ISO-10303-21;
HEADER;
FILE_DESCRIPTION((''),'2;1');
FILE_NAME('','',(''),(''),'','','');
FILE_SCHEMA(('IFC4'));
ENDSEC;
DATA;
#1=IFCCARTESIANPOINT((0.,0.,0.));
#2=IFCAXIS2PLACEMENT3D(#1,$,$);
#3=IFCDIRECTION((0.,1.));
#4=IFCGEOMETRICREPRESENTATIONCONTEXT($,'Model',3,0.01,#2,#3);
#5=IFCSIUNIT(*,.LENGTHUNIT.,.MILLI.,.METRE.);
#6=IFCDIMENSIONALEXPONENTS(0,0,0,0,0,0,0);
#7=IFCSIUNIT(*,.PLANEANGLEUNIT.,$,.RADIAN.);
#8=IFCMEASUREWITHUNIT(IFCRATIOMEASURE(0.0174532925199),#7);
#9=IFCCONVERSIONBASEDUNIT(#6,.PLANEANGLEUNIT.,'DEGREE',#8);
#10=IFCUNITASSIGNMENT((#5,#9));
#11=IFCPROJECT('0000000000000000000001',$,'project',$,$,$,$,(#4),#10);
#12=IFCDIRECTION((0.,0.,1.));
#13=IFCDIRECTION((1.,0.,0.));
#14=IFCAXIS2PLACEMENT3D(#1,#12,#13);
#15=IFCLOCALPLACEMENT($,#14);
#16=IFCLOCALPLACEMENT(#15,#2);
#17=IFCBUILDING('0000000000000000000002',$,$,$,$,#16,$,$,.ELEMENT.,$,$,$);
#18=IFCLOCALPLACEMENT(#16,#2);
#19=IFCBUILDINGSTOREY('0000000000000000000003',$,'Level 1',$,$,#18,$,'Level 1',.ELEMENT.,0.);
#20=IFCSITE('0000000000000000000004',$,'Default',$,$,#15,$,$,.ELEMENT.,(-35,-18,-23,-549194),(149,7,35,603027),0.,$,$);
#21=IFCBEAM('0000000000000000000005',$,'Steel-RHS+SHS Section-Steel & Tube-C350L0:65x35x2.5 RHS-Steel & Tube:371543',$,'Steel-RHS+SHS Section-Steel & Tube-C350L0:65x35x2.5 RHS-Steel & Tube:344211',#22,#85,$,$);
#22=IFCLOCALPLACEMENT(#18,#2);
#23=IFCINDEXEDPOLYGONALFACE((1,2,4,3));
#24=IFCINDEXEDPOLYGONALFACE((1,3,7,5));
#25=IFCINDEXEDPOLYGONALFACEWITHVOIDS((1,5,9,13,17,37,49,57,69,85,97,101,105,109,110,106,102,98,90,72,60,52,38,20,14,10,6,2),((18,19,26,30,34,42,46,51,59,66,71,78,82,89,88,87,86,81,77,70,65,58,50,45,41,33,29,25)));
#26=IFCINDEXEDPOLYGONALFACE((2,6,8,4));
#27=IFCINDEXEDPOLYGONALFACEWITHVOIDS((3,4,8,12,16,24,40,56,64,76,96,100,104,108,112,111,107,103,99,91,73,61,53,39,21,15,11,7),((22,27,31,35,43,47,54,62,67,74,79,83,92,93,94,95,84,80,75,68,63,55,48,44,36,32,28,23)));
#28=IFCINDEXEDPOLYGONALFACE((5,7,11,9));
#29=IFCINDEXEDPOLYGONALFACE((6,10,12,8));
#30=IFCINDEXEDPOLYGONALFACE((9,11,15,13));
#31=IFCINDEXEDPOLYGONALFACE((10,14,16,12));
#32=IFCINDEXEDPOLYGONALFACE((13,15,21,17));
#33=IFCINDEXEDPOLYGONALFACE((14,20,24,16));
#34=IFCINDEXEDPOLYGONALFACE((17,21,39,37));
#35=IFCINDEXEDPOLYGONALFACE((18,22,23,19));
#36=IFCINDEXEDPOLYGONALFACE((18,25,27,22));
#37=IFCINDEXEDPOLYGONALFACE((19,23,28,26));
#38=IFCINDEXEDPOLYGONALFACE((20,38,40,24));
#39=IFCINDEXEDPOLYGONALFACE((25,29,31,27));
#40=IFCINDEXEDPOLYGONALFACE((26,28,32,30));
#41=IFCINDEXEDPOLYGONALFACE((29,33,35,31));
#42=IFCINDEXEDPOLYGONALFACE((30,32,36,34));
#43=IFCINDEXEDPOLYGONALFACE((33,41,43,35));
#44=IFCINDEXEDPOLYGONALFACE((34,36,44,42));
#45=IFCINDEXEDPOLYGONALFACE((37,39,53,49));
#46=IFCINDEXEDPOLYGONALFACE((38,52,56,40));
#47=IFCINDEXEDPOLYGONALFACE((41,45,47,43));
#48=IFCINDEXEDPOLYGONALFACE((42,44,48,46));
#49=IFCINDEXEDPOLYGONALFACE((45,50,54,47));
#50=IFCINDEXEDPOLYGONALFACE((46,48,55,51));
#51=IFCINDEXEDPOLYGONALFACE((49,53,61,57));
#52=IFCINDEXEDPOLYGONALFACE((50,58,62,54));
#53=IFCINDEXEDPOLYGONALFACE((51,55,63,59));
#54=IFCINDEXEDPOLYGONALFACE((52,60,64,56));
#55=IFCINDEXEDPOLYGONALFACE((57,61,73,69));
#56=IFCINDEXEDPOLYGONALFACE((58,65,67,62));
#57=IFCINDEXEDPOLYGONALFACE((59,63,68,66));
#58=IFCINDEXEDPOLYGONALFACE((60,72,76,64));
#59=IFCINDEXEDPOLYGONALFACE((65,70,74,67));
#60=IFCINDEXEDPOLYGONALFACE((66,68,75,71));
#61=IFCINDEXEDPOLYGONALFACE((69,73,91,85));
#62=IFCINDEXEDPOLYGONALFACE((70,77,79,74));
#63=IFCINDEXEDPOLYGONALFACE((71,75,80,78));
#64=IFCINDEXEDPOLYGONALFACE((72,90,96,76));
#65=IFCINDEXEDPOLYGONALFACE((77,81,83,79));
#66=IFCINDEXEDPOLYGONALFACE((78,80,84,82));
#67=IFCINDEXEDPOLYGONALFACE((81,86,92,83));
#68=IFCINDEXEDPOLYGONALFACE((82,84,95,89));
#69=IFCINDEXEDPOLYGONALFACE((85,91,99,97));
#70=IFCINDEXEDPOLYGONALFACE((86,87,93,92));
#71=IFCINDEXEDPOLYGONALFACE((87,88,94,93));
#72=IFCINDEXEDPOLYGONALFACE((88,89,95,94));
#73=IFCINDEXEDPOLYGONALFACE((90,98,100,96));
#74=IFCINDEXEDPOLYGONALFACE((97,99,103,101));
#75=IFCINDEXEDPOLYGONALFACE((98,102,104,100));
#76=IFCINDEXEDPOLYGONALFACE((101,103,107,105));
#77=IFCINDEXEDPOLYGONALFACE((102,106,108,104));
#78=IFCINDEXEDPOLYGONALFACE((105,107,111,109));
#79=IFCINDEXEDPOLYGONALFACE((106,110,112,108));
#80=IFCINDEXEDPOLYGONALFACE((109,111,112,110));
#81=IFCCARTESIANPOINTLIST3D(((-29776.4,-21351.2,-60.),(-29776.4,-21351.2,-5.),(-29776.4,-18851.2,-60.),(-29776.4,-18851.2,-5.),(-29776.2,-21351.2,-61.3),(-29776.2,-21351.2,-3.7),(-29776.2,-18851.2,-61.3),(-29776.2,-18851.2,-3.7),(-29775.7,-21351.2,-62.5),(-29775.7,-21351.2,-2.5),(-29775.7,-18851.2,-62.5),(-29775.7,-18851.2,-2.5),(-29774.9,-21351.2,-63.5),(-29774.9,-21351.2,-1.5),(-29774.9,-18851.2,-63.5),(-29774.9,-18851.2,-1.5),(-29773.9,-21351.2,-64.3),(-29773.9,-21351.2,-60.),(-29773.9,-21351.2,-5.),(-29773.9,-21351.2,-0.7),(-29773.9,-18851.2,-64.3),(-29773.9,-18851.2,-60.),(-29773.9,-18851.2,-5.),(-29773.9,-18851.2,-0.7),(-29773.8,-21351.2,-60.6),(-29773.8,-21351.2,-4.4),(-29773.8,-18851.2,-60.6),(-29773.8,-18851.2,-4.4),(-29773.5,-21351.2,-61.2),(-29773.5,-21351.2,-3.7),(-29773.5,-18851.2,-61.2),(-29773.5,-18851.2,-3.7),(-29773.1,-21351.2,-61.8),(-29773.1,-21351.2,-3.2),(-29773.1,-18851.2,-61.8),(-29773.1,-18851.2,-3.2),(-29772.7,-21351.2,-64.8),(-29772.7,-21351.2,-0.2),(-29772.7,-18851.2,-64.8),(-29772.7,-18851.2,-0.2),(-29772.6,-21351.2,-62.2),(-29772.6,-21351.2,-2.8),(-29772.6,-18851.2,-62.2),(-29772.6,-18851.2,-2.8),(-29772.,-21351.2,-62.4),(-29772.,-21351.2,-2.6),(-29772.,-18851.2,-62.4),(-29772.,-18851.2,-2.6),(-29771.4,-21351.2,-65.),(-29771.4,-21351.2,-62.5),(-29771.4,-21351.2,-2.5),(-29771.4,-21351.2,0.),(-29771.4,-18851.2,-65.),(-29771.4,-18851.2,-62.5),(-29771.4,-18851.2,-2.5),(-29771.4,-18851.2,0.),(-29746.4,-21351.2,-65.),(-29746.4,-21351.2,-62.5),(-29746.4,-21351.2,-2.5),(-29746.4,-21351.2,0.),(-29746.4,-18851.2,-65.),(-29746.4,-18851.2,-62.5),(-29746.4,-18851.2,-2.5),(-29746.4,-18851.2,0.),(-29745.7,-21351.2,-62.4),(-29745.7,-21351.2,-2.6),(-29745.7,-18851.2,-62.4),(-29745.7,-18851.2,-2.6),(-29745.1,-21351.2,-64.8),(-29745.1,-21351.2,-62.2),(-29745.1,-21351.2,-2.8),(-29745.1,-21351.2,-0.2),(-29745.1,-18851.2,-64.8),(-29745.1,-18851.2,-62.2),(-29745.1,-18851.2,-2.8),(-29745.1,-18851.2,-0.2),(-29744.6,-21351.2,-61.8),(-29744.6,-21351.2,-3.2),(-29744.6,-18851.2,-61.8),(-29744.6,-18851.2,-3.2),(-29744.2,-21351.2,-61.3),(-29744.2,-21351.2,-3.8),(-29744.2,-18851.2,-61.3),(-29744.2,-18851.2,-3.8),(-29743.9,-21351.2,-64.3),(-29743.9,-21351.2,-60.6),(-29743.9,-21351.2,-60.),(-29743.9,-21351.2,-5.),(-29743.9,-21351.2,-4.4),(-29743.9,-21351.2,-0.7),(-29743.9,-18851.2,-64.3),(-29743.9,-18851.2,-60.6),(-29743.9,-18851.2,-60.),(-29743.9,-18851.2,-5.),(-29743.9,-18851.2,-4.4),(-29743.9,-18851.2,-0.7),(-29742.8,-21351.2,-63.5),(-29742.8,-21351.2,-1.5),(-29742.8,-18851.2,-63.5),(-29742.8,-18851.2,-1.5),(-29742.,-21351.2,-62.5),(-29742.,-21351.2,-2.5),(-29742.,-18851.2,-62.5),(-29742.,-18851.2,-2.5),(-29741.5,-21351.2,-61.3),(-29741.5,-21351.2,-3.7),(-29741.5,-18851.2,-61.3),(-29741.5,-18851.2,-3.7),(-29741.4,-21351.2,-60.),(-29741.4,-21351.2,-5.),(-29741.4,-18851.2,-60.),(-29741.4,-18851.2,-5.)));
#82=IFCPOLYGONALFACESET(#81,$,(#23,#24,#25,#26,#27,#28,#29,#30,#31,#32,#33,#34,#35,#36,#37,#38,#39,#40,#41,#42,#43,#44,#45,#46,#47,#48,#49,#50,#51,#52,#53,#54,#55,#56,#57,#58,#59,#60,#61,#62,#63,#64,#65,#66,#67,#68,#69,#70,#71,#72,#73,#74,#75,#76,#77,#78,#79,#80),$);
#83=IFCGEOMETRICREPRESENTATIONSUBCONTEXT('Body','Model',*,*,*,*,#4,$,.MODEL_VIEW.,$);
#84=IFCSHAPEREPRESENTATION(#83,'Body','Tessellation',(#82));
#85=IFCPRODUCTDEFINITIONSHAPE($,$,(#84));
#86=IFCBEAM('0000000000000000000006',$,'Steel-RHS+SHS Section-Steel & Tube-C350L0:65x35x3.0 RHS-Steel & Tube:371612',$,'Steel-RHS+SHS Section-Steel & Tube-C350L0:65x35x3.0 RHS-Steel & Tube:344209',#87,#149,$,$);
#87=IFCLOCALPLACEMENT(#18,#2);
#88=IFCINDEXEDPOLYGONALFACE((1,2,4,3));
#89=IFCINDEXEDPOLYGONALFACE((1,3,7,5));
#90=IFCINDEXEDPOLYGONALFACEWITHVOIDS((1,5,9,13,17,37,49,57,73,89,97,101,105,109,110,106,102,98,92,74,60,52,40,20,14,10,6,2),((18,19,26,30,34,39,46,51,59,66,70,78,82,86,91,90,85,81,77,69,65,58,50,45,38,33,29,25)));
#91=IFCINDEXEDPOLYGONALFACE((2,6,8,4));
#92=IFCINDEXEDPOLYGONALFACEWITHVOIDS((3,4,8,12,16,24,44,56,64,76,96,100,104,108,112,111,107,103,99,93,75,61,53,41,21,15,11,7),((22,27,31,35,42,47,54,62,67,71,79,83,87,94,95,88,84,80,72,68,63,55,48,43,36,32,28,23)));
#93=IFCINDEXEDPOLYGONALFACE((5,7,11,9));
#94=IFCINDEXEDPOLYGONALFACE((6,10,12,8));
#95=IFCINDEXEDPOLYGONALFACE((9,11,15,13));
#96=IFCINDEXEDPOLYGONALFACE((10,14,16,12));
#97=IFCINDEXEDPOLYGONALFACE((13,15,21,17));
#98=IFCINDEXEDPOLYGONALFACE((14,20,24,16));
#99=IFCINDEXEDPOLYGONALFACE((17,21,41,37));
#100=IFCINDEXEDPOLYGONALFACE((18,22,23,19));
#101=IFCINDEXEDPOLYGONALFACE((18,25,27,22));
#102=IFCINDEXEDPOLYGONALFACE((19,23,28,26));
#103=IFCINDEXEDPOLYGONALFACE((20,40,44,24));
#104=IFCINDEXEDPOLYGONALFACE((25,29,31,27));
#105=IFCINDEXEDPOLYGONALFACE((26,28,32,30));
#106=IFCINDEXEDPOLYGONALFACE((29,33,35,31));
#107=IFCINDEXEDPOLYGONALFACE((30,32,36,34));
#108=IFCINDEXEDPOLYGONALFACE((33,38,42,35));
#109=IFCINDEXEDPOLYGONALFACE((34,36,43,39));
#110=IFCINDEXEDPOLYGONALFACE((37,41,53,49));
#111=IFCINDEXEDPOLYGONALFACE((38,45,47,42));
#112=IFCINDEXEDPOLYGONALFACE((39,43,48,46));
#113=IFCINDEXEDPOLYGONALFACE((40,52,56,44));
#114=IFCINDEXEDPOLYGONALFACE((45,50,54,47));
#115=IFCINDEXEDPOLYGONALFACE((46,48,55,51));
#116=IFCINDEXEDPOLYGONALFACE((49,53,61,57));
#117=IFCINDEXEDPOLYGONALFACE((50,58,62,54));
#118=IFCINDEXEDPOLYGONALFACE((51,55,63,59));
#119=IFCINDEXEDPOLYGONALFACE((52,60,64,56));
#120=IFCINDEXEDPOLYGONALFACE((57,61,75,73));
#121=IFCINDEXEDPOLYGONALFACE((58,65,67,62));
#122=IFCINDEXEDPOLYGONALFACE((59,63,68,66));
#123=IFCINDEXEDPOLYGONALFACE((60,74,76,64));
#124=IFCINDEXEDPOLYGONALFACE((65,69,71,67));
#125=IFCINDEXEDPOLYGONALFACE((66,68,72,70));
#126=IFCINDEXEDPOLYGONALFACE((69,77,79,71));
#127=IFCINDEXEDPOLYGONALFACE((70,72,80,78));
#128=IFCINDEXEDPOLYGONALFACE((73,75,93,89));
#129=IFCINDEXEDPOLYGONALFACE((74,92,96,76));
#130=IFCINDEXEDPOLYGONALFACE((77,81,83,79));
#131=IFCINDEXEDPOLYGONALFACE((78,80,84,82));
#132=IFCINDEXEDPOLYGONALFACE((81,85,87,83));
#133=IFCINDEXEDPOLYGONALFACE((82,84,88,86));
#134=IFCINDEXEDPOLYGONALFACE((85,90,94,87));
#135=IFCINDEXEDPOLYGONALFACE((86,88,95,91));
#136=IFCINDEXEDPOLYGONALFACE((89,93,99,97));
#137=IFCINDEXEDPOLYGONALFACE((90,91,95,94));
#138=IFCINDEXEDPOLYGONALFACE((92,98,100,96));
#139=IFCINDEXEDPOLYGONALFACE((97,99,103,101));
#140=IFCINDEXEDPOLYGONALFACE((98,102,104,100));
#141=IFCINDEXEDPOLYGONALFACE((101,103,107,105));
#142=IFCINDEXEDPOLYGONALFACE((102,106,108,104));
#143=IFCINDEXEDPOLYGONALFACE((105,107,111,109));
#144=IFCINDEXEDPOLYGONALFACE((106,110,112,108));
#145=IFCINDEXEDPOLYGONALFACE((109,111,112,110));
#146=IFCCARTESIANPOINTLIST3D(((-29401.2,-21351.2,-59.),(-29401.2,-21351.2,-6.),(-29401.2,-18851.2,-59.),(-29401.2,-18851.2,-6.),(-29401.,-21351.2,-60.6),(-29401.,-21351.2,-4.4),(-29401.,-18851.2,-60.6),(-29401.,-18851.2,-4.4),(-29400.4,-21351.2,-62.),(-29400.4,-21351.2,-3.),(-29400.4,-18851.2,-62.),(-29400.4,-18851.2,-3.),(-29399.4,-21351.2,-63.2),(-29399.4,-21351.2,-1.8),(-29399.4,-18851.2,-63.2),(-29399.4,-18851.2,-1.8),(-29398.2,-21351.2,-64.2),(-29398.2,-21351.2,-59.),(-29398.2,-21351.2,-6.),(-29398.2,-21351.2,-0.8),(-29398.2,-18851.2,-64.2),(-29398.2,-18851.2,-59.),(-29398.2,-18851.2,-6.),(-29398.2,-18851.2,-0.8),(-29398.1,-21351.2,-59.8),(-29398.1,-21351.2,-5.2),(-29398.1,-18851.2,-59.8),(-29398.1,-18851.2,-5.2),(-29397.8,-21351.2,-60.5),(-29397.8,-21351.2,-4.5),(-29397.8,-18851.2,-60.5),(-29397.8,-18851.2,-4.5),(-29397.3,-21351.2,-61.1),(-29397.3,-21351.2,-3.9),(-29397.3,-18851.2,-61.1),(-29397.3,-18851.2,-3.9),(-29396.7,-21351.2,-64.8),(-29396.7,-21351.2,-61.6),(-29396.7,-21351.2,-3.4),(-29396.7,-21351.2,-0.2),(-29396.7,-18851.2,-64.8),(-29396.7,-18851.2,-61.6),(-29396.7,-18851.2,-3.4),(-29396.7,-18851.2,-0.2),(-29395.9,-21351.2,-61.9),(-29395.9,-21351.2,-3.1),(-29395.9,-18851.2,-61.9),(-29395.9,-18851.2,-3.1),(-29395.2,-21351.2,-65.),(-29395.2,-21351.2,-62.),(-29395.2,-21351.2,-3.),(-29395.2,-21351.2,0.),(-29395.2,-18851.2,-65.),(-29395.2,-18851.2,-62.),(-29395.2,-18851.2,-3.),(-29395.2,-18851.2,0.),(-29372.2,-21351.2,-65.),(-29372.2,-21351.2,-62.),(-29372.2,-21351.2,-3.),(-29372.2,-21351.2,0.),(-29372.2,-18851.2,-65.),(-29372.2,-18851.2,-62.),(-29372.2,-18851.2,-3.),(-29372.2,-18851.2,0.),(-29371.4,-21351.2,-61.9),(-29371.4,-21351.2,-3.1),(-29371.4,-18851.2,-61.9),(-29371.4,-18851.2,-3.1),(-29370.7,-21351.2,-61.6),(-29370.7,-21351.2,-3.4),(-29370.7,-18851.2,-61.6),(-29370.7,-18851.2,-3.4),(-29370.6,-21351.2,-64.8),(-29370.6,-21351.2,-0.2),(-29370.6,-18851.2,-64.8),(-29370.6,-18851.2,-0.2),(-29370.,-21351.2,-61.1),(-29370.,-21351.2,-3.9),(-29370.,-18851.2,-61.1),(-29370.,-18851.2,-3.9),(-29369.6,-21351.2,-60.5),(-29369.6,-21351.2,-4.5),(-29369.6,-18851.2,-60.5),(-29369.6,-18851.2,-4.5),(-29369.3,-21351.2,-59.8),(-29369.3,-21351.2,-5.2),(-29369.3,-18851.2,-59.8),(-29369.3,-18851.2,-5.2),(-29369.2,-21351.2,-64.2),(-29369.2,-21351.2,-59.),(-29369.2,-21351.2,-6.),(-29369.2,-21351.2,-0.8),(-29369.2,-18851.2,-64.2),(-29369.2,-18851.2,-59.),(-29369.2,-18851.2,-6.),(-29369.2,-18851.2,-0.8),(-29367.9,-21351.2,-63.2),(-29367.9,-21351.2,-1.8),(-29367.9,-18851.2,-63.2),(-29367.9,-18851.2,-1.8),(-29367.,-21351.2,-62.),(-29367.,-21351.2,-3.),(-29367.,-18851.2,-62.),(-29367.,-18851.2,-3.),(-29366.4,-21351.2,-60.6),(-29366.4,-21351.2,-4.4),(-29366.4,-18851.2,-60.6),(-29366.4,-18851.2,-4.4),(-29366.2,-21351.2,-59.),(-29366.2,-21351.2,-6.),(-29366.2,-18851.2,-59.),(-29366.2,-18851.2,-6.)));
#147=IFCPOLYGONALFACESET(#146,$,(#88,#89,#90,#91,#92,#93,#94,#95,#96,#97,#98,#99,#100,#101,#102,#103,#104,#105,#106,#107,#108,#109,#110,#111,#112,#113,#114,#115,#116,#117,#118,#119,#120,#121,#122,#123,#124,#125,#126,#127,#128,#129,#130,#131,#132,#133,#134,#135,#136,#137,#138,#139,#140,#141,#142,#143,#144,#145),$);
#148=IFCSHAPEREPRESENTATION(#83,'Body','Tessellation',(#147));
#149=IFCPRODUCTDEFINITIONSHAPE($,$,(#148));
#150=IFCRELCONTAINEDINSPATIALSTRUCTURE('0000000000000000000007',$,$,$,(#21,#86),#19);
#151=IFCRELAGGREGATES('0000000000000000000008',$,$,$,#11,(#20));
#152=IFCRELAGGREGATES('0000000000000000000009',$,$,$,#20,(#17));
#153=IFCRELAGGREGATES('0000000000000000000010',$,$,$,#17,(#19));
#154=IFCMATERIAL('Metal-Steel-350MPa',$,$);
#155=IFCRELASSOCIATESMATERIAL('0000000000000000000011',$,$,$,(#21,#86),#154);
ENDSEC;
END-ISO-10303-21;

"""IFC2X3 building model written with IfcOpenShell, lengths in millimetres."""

from ifc_helpers import new_model, entity, si_unit, converted_unit, direction, frame, frame_2d, origin, origin_with_axes, place, context, subcontext, project, spatial, polyline, circle_curve, parameter, trimmed, segment, composite_curve, outline, extrude, material, element, save


model = new_model("IFC2X3")

# Units and contexts
model_context = context("Model", 3, precision=0.01, world=origin(), true_north=direction((0.0, 1.0)))
body_context = subcontext(model_context, "Body", "Model", "MODEL_VIEW")
ifc_project = project(units=[si_unit("LENGTHUNIT", "METRE", prefix="MILLI"), converted_unit("PLANEANGLEUNIT", "DEGREE", entity("IfcRatioMeasure", 0.0174532925199), si_unit("PLANEANGLEUNIT", "RADIAN"), dimensions=[0, 0, 0, 0, 0, 0, 0])], contexts=[model_context])

# Site, building, storey
site_placement = place(None, origin_with_axes())
site = spatial("IfcSite", under=ifc_project, at=site_placement, Name="Default", CompositionType="ELEMENT", RefLatitude=(-35, -18, -23, -549194), RefLongitude=(149, 7, 35, 603027), RefElevation=0.0)
building_placement = place(site_placement, origin())
building = spatial("IfcBuilding", under=site, at=building_placement, CompositionType="ELEMENT")
storey_placement = place(building_placement, origin())
storey = spatial("IfcBuildingStorey", under=building, at=storey_placement, Name="Level 1", LongName="Level 1", CompositionType="ELEMENT", Elevation=0.0)

# Beams
ifc_material = material(Name="Metal-Steel-350MPa")
beam_1_placement = place(storey_placement, frame((-29758.9, -18851.2, 0.0), z_axis=(0.0, 0.0, 1.0), x_axis=(0.0, -1.0, 0.0)))
element("IfcBeam", 1, at=beam_1_placement, inside=storey, material=ifc_material, Name="Steel-RHS+SHS Section-Steel & Tube-C350L0:65x35x2.5 RHS-Steel & Tube:371543", ObjectType="Steel-RHS+SHS Section-Steel & Tube-C350L0:65x35x2.5 RHS-Steel & Tube:344211", context=body_context, shape_type="SweptSolid", body=[
    extrude(outline(composite_curve([segment(trimmed(circle_curve(frame_2d((-12.5, -27.5), x_axis=(1.0, 0.0)), 5.0), [parameter(180.0)], [parameter(270.0)], True, "PARAMETER"), True, "CONTINUOUS"), segment(polyline([(-12.5, -32.5), (12.5, -32.5)]), True, "CONTINUOUS"), segment(trimmed(circle_curve(frame_2d((12.5, -27.5), x_axis=(1.0, 0.0)), 5.0), [parameter(270.0)], [parameter(0.0)], True, "PARAMETER"), True, "CONTINUOUS"), segment(polyline([(17.5, -27.5), (17.5, 27.5)]), True, "CONTINUOUS"), segment(trimmed(circle_curve(frame_2d((12.5, 27.5), x_axis=(1.0, 0.0)), 5.0), [parameter(0.0)], [parameter(90.0)], True, "PARAMETER"), True, "CONTINUOUS"), segment(polyline([(12.5, 32.5), (-12.5, 32.5)]), True, "CONTINUOUS"), segment(trimmed(circle_curve(frame_2d((-12.5, 27.5), x_axis=(1.0, 0.0)), 5.0), [parameter(90.0)], [parameter(180.0)], True, "PARAMETER"), True, "CONTINUOUS"), segment(polyline([(-17.5, 27.5), (-17.5, -27.5)]), True, "CONTINUOUS")], self_intersect=False), holes=[composite_curve([segment(polyline([(12.5, -30.0), (-12.5, -30.0)]), True, "CONTINUOUS"), segment(trimmed(circle_curve(frame_2d((-12.5, -27.5), x_axis=(1.0, 0.0)), 2.5), [parameter(180.0)], [parameter(270.0)], True, "PARAMETER"), False, "CONTINUOUS"), segment(polyline([(-15.0, -27.5), (-15.0, 27.5)]), True, "CONTINUOUS"), segment(trimmed(circle_curve(frame_2d((-12.5, 27.5), x_axis=(1.0, 0.0)), 2.5), [parameter(90.0)], [parameter(180.0)], True, "PARAMETER"), False, "CONTINUOUS"), segment(polyline([(-12.5, 30.0), (12.5, 30.0)]), True, "CONTINUOUS"), segment(trimmed(circle_curve(frame_2d((12.5, 27.5), x_axis=(1.0, 0.0)), 2.5), [parameter(360.0)], [parameter(90.0)], True, "PARAMETER"), False, "CONTINUOUS"), segment(polyline([(15.0, 27.5), (15.0, -27.5)]), True, "CONTINUOUS"), segment(trimmed(circle_curve(frame_2d((12.5, -27.5), x_axis=(1.0, 0.0)), 2.5), [parameter(270.0)], [parameter(360.0)], True, "PARAMETER"), False, "CONTINUOUS")], self_intersect=False)]), frame((0.0, 0.0, -32.5), z_axis=(1.0, 0.0, 0.0), x_axis=(0.0, -1.0, 0.0)), (0.0, 0.0, 1.0), 2500.0),
])
beam_2_placement = place(storey_placement, frame((-29383.7, -18851.2, 0.0), z_axis=(0.0, 0.0, 1.0), x_axis=(0.0, -1.0, 0.0)))
element("IfcBeam", 2, at=beam_2_placement, inside=storey, material=ifc_material, Name="Steel-RHS+SHS Section-Steel & Tube-C350L0:65x35x3.0 RHS-Steel & Tube:371612", ObjectType="Steel-RHS+SHS Section-Steel & Tube-C350L0:65x35x3.0 RHS-Steel & Tube:344209", context=body_context, shape_type="SweptSolid", body=[
    extrude(outline(composite_curve([segment(trimmed(circle_curve(frame_2d((-11.5, -26.5), x_axis=(1.0, 0.0)), 6.0), [parameter(180.0)], [parameter(270.0)], True, "PARAMETER"), True, "CONTINUOUS"), segment(polyline([(-11.5, -32.5), (11.5, -32.5)]), True, "CONTINUOUS"), segment(trimmed(circle_curve(frame_2d((11.5, -26.5), x_axis=(1.0, 0.0)), 6.0), [parameter(270.0)], [parameter(0.0)], True, "PARAMETER"), True, "CONTINUOUS"), segment(polyline([(17.5, -26.5), (17.5, 26.5)]), True, "CONTINUOUS"), segment(trimmed(circle_curve(frame_2d((11.5, 26.5), x_axis=(1.0, 0.0)), 6.0), [parameter(0.0)], [parameter(90.0)], True, "PARAMETER"), True, "CONTINUOUS"), segment(polyline([(11.5, 32.5), (-11.5, 32.5)]), True, "CONTINUOUS"), segment(trimmed(circle_curve(frame_2d((-11.5, 26.5), x_axis=(1.0, 0.0)), 6.0), [parameter(90.0)], [parameter(180.0)], True, "PARAMETER"), True, "CONTINUOUS"), segment(polyline([(-17.5, 26.5), (-17.5, -26.5)]), True, "CONTINUOUS")], self_intersect=False), holes=[composite_curve([segment(polyline([(11.5, -29.5), (-11.5, -29.5)]), True, "CONTINUOUS"), segment(trimmed(circle_curve(frame_2d((-11.5, -26.5), x_axis=(1.0, 0.0)), 3.0), [parameter(180.0)], [parameter(270.0)], True, "PARAMETER"), False, "CONTINUOUS"), segment(polyline([(-14.5, -26.5), (-14.5, 26.5)]), True, "CONTINUOUS"), segment(trimmed(circle_curve(frame_2d((-11.5, 26.5), x_axis=(1.0, 0.0)), 3.0), [parameter(90.0)], [parameter(180.0)], True, "PARAMETER"), False, "CONTINUOUS"), segment(polyline([(-11.5, 29.5), (11.5, 29.5)]), True, "CONTINUOUS"), segment(trimmed(circle_curve(frame_2d((11.5, 26.5), x_axis=(1.0, 0.0)), 3.0), [parameter(360.0)], [parameter(90.0)], True, "PARAMETER"), False, "CONTINUOUS"), segment(polyline([(14.5, 26.5), (14.5, -26.5)]), True, "CONTINUOUS"), segment(trimmed(circle_curve(frame_2d((11.5, -26.5), x_axis=(1.0, 0.0)), 3.0), [parameter(270.0)], [parameter(0.0)], True, "PARAMETER"), False, "CONTINUOUS")], self_intersect=False)]), frame((0.0, 0.0, -32.5), z_axis=(1.0, 0.0, 0.0), x_axis=(0.0, -1.0, 0.0)), (0.0, 0.0, 1.0), 2500.0),
])

save(model, "model.ifc")
